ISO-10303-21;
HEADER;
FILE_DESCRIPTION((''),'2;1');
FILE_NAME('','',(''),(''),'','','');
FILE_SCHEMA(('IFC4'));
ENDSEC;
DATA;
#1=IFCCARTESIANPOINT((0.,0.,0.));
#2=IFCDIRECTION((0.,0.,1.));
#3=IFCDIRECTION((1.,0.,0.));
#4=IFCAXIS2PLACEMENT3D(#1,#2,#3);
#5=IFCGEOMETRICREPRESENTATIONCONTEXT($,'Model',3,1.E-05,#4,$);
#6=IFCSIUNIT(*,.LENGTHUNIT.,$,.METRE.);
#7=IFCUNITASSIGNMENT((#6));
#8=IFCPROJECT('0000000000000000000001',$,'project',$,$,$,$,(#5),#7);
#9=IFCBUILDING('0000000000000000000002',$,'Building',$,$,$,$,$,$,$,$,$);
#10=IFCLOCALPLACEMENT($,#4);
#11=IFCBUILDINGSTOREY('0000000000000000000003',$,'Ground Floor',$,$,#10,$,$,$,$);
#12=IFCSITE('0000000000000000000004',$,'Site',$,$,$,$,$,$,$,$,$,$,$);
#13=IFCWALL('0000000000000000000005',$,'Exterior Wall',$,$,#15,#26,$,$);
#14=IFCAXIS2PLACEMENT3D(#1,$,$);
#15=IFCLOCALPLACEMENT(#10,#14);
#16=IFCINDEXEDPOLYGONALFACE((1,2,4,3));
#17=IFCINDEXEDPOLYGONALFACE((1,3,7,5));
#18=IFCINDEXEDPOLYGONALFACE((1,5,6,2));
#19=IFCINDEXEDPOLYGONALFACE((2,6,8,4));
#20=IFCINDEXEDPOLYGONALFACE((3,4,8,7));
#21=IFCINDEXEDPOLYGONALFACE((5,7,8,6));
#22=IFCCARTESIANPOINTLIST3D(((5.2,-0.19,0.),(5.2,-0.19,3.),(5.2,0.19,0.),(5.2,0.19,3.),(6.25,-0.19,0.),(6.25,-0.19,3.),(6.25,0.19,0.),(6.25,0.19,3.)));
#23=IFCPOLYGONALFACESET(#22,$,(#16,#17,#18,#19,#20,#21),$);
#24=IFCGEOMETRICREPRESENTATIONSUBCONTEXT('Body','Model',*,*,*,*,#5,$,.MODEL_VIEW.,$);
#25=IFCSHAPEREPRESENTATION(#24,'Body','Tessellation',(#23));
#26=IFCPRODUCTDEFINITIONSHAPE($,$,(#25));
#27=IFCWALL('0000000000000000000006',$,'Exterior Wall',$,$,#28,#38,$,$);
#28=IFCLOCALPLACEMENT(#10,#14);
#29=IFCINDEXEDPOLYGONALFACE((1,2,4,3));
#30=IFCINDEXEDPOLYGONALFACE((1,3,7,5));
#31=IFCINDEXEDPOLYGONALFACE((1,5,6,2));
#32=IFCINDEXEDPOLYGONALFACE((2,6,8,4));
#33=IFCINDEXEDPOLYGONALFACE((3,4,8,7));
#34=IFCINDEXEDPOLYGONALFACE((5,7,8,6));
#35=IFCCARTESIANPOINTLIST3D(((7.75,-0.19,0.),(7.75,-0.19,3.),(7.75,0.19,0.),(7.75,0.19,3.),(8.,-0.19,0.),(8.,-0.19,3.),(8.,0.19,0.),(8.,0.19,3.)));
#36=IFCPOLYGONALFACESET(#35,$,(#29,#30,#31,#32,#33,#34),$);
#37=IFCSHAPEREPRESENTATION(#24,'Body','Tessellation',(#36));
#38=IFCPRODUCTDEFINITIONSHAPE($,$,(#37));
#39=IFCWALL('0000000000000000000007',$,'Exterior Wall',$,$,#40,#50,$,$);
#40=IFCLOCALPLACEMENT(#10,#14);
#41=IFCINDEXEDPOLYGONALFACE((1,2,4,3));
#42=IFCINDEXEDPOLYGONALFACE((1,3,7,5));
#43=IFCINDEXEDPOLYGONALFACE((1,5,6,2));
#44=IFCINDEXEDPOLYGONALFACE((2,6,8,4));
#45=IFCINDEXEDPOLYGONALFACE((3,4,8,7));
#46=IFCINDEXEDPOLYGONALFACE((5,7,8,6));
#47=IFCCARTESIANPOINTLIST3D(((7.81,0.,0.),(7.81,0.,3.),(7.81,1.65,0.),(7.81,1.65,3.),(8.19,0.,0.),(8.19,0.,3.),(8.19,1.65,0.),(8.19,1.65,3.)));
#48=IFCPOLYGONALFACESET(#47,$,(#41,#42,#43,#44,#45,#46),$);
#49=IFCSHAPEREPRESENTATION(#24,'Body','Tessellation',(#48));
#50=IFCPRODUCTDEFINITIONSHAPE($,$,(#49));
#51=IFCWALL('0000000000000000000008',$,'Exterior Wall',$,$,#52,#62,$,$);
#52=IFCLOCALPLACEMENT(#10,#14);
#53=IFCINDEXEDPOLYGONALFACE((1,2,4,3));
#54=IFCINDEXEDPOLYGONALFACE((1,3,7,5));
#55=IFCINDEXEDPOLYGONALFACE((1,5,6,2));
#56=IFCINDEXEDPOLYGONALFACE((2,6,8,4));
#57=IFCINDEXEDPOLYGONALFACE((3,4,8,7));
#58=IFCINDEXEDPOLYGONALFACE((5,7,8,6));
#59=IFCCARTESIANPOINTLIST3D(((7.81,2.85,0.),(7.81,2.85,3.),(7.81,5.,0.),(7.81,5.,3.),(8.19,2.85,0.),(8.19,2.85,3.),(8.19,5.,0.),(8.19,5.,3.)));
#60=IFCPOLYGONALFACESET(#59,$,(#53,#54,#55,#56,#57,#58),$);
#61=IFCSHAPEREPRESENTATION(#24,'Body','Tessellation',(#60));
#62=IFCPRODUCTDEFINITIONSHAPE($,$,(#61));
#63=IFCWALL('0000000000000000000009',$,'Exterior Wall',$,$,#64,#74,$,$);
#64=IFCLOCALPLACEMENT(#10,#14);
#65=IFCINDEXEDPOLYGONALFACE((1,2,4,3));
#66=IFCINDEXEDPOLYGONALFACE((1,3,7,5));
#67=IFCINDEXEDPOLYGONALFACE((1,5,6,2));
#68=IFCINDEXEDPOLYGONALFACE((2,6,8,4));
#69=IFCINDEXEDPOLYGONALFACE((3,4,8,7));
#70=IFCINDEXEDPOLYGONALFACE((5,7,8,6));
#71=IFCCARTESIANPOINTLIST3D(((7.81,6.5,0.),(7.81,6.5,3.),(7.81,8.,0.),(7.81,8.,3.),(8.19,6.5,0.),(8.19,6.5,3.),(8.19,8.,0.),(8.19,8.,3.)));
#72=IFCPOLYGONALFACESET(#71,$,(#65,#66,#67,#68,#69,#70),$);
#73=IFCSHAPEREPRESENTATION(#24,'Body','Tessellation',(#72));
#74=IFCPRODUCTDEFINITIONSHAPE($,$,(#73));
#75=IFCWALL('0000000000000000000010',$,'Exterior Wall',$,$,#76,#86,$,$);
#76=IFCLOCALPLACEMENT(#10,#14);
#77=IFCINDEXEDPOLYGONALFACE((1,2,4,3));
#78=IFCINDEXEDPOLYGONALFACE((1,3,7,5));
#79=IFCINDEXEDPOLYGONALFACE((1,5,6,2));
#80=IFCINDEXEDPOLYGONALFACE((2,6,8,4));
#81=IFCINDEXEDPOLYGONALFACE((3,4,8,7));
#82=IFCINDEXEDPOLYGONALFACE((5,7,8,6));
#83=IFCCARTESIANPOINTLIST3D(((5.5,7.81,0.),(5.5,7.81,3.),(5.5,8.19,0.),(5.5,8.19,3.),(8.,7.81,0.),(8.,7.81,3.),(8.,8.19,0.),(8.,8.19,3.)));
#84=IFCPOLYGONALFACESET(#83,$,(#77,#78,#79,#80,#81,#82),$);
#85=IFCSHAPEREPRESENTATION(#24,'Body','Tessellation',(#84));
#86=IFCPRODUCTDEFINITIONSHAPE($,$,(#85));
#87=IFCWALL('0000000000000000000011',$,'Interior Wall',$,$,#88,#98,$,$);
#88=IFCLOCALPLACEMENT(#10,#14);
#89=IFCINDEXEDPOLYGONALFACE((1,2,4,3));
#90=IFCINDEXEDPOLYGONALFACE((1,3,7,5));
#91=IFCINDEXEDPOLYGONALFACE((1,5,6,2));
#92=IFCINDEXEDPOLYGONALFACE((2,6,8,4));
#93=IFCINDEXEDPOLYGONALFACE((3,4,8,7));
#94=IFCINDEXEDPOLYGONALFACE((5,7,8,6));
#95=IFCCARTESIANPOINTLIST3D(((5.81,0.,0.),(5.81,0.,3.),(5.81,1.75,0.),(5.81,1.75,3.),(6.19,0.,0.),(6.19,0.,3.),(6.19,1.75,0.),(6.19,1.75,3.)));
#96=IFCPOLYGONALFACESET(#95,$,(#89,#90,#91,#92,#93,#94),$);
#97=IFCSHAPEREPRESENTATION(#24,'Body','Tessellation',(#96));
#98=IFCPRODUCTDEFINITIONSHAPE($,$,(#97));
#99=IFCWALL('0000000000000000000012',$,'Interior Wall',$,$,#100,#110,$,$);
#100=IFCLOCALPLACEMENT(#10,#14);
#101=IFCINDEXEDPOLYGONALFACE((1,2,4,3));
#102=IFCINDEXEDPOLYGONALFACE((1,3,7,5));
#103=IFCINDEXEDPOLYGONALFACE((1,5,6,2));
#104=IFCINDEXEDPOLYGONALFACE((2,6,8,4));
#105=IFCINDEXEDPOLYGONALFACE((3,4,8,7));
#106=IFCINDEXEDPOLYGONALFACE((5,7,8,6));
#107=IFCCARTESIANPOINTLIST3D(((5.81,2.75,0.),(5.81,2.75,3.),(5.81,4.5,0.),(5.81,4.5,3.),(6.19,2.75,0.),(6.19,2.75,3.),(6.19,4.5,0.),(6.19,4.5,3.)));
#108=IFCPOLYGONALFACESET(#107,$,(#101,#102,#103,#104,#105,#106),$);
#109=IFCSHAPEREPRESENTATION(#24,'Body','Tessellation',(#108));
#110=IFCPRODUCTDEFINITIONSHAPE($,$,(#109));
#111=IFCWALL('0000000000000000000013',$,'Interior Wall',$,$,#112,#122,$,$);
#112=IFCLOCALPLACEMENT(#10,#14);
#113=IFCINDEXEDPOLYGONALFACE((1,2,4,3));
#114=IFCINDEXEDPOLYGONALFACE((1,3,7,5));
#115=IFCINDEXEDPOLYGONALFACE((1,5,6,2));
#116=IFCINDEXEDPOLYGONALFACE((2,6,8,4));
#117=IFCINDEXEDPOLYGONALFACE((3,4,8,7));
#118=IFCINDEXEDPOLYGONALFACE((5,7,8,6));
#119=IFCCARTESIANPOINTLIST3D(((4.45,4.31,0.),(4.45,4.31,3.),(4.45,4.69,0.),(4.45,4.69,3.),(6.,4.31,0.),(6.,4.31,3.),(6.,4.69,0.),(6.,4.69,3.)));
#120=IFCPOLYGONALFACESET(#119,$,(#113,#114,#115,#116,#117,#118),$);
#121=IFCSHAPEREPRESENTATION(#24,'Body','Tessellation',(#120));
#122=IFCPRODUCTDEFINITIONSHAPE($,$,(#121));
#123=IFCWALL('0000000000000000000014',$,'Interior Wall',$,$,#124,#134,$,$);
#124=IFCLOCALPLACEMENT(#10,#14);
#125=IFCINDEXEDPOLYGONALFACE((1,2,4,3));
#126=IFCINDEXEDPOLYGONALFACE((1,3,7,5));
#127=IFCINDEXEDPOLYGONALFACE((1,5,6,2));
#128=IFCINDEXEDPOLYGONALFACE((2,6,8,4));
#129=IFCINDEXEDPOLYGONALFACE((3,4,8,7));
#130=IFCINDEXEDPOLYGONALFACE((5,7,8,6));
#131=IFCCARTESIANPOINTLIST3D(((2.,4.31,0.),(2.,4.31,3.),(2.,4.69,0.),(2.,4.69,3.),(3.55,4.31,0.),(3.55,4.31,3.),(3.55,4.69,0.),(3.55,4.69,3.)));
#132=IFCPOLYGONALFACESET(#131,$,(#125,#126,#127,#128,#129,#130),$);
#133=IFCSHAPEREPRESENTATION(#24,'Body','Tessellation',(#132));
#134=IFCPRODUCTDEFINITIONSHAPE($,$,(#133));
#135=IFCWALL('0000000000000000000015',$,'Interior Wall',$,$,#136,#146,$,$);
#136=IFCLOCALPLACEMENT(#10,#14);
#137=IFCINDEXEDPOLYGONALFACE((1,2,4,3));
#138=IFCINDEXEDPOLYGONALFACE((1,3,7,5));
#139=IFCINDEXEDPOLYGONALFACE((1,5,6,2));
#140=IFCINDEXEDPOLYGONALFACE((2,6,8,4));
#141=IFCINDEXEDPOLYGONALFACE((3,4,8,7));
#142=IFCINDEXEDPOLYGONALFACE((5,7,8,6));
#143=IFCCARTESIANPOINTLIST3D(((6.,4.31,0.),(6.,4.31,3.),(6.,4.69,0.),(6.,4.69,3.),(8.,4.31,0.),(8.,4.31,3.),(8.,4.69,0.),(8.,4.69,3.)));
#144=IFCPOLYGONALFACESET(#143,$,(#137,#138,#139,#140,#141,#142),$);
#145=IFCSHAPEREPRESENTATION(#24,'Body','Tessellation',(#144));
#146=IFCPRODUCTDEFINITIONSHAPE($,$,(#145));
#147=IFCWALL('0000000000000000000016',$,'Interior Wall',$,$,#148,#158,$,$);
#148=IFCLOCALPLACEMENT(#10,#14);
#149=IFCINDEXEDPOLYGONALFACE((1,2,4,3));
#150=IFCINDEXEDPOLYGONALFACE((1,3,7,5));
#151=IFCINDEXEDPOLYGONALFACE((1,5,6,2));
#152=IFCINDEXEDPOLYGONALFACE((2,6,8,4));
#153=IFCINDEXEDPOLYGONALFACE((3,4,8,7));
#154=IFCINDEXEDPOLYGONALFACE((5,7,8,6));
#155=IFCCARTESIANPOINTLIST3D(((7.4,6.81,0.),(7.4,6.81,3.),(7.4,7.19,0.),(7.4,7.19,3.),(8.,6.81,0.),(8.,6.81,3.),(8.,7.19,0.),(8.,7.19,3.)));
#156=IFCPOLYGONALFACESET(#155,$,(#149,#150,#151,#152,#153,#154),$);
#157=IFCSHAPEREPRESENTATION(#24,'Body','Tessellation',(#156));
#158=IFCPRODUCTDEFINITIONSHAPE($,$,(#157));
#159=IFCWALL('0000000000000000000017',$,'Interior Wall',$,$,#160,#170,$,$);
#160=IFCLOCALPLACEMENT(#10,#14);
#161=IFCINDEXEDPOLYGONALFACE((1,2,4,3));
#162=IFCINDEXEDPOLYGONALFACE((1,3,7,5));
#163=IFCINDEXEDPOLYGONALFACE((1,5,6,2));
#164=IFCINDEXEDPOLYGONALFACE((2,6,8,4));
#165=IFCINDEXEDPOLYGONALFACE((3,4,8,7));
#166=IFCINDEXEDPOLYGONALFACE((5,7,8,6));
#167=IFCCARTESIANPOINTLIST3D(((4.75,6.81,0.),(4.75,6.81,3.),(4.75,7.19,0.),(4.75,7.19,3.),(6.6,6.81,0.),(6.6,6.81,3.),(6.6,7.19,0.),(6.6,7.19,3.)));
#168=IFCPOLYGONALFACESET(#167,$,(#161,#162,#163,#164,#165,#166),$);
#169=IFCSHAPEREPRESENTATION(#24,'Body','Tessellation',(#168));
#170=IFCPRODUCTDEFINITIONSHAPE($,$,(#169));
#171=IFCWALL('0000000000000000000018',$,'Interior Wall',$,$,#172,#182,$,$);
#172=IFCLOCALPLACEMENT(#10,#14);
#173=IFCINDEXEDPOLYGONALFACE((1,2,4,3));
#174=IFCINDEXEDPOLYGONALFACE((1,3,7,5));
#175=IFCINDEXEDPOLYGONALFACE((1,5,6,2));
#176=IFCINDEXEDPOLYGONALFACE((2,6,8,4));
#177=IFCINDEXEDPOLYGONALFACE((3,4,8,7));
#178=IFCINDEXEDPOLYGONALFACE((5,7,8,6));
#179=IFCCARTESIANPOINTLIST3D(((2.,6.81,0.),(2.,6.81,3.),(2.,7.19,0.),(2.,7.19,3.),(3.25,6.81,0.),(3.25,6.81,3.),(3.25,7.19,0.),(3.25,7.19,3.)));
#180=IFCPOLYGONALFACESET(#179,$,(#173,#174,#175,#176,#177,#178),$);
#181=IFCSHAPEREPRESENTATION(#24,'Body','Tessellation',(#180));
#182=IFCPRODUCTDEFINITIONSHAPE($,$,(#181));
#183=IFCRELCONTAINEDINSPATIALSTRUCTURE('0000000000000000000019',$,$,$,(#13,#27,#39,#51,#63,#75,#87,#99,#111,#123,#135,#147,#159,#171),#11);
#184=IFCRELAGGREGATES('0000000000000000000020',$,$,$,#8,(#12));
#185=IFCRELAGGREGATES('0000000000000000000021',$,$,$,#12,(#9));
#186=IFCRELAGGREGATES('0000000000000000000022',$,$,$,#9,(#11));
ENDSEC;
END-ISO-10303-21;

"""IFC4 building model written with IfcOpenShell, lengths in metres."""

from ifc_helpers import new_model, si_unit, frame, origin_with_axes, place, context, subcontext, project, spatial, indexed_curve, outline, extrude, element, save


model = new_model("IFC4")

# Units and contexts
model_context = context("Model", 3, precision=1e-05, world=origin_with_axes())
body_context = subcontext(model_context, "Body", "Model", "MODEL_VIEW")
ifc_project = project(units=[si_unit("LENGTHUNIT", "METRE")], contexts=[model_context])

# Site, building, storey
site = spatial("IfcSite", under=ifc_project, Name="Site")
building = spatial("IfcBuilding", under=site, Name="Building")
storey_placement = place(None, origin_with_axes())
storey = spatial("IfcBuildingStorey", under=building, at=storey_placement, Name="Ground Floor")

# Walls
wall_1_placement = place(storey_placement, frame((5.2, 0.0, 0.0), z_axis=(0.0, 0.0, 1.0), x_axis=(1.0, 0.0, 0.0)))
element("IfcWall", 1, at=wall_1_placement, inside=storey, Name="Exterior Wall", context=body_context, shape_type="SweptSolid", body=[
    extrude(outline(indexed_curve([(0.0, 0.0), (0.0, 0.38), (1.05, 0.38), (1.05, 0.0), (0.0, 0.0)], self_intersect=False)), frame((0.0, -0.19, 0.0), z_axis=(0.0, 0.0, 1.0), x_axis=(1.0, 0.0, 0.0)), (0.0, 0.0, 1.0), 3.0),
])
wall_2_placement = place(storey_placement, frame((7.75, 0.0, 0.0), z_axis=(0.0, 0.0, 1.0), x_axis=(1.0, 0.0, 0.0)))
element("IfcWall", 2, at=wall_2_placement, inside=storey, Name="Exterior Wall", context=body_context, shape_type="SweptSolid", body=[
    extrude(outline(indexed_curve([(0.0, 0.0), (0.0, 0.38), (0.25, 0.38), (0.25, 0.0), (0.0, 0.0)], self_intersect=False)), frame((0.0, -0.19, 0.0), z_axis=(0.0, 0.0, 1.0), x_axis=(1.0, 0.0, 0.0)), (0.0, 0.0, 1.0), 3.0),
])
wall_3_placement = place(storey_placement, frame((8.0, 0.0, 0.0), z_axis=(0.0, 0.0, 1.0), x_axis=(0.0, 1.0, 0.0)))
element("IfcWall", 3, at=wall_3_placement, inside=storey, Name="Exterior Wall", context=body_context, shape_type="SweptSolid", body=[
    extrude(outline(indexed_curve([(0.0, 0.0), (0.0, 0.38), (1.65, 0.38), (1.65, 0.0), (0.0, 0.0)], self_intersect=False)), frame((0.0, -0.19, 0.0), z_axis=(0.0, 0.0, 1.0), x_axis=(1.0, 0.0, 0.0)), (0.0, 0.0, 1.0), 3.0),
])
wall_4_placement = place(storey_placement, frame((8.0, 2.85, 0.0), z_axis=(0.0, 0.0, 1.0), x_axis=(0.0, 1.0, 0.0)))
element("IfcWall", 4, at=wall_4_placement, inside=storey, Name="Exterior Wall", context=body_context, shape_type="SweptSolid", body=[
    extrude(outline(indexed_curve([(0.0, 0.0), (0.0, 0.38), (2.15, 0.38), (2.15, 0.0), (0.0, 0.0)], self_intersect=False)), frame((0.0, -0.19, 0.0), z_axis=(0.0, 0.0, 1.0), x_axis=(1.0, 0.0, 0.0)), (0.0, 0.0, 1.0), 3.0),
])
wall_5_placement = place(storey_placement, frame((8.0, 6.5, 0.0), z_axis=(0.0, 0.0, 1.0), x_axis=(0.0, 1.0, 0.0)))
element("IfcWall", 5, at=wall_5_placement, inside=storey, Name="Exterior Wall", context=body_context, shape_type="SweptSolid", body=[
    extrude(outline(indexed_curve([(0.0, 0.0), (0.0, 0.38), (1.5, 0.38), (1.5, 0.0), (0.0, 0.0)], self_intersect=False)), frame((0.0, -0.19, 0.0), z_axis=(0.0, 0.0, 1.0), x_axis=(1.0, 0.0, 0.0)), (0.0, 0.0, 1.0), 3.0),
])
wall_6_placement = place(storey_placement, frame((8.0, 8.0, 0.0), z_axis=(0.0, 0.0, 1.0), x_axis=(-1.0, 0.0, 0.0)))
element("IfcWall", 6, at=wall_6_placement, inside=storey, Name="Exterior Wall", context=body_context, shape_type="SweptSolid", body=[
    extrude(outline(indexed_curve([(0.0, 0.0), (0.0, 0.38), (2.5, 0.38), (2.5, 0.0), (0.0, 0.0)], self_intersect=False)), frame((0.0, -0.19, 0.0), z_axis=(0.0, 0.0, 1.0), x_axis=(1.0, 0.0, 0.0)), (0.0, 0.0, 1.0), 3.0),
])
for number, where, z_axis, x_axis, name in (
    (7, (6.0, 0.0, 0.0), (0.0, 0.0, 1.0), (0.0, 1.0, 0.0), "Interior Wall"),
    (8, (6.0, 2.75, 0.0), (0.0, 0.0, 1.0), (0.0, 1.0, 0.0), "Interior Wall"),
):
    element("IfcWall", number, at=place(storey_placement, frame(where, z_axis=z_axis, x_axis=x_axis)), inside=storey, Name=name, context=body_context, shape_type="SweptSolid", body=[
        extrude(outline(indexed_curve([(0.0, 0.0), (0.0, 0.38), (1.75, 0.38), (1.75, 0.0), (0.0, 0.0)], self_intersect=False)), frame((0.0, -0.19, 0.0), z_axis=(0.0, 0.0, 1.0), x_axis=(1.0, 0.0, 0.0)), (0.0, 0.0, 1.0), 3.0),
    ])
for number, where, z_axis, x_axis, name in (
    (9, (6.0, 4.5, 0.0), (0.0, 0.0, 1.0), (-1.0, 0.0, 0.0), "Interior Wall"),
    (10, (3.55, 4.5, 0.0), (0.0, 0.0, 1.0), (-1.0, 0.0, 0.0), "Interior Wall"),
):
    element("IfcWall", number, at=place(storey_placement, frame(where, z_axis=z_axis, x_axis=x_axis)), inside=storey, Name=name, context=body_context, shape_type="SweptSolid", body=[
        extrude(outline(indexed_curve([(0.0, 0.0), (0.0, 0.38), (1.55, 0.38), (1.55, 0.0), (0.0, 0.0)], self_intersect=False)), frame((0.0, -0.19, 0.0), z_axis=(0.0, 0.0, 1.0), x_axis=(1.0, 0.0, 0.0)), (0.0, 0.0, 1.0), 3.0),
    ])
wall_7_placement = place(storey_placement, frame((8.0, 4.5, 0.0), z_axis=(0.0, 0.0, 1.0), x_axis=(-1.0, 0.0, 0.0)))
element("IfcWall", 11, at=wall_7_placement, inside=storey, Name="Interior Wall", context=body_context, shape_type="SweptSolid", body=[
    extrude(outline(indexed_curve([(0.0, 0.0), (0.0, 0.38), (2.0, 0.38), (2.0, 0.0), (0.0, 0.0)], self_intersect=False)), frame((0.0, -0.19, 0.0), z_axis=(0.0, 0.0, 1.0), x_axis=(1.0, 0.0, 0.0)), (0.0, 0.0, 1.0), 3.0),
])
wall_8_placement = place(storey_placement, frame((8.0, 7.0, 0.0), z_axis=(0.0, 0.0, 1.0), x_axis=(-1.0, 0.0, 0.0)))
element("IfcWall", 12, at=wall_8_placement, inside=storey, Name="Interior Wall", context=body_context, shape_type="SweptSolid", body=[
    extrude(outline(indexed_curve([(0.0, 0.0), (0.0, 0.38), (0.6, 0.38), (0.6, 0.0), (0.0, 0.0)], self_intersect=False)), frame((0.0, -0.19, 0.0), z_axis=(0.0, 0.0, 1.0), x_axis=(1.0, 0.0, 0.0)), (0.0, 0.0, 1.0), 3.0),
])
wall_9_placement = place(storey_placement, frame((6.6, 7.0, 0.0), z_axis=(0.0, 0.0, 1.0), x_axis=(-1.0, 0.0, 0.0)))
element("IfcWall", 13, at=wall_9_placement, inside=storey, Name="Interior Wall", context=body_context, shape_type="SweptSolid", body=[
    extrude(outline(indexed_curve([(0.0, 0.0), (0.0, 0.38), (1.85, 0.38), (1.85, 0.0), (0.0, 0.0)], self_intersect=False)), frame((0.0, -0.19, 0.0), z_axis=(0.0, 0.0, 1.0), x_axis=(1.0, 0.0, 0.0)), (0.0, 0.0, 1.0), 3.0),
])
wall_10_placement = place(storey_placement, frame((3.25, 7.0, 0.0), z_axis=(0.0, 0.0, 1.0), x_axis=(-1.0, 0.0, 0.0)))
element("IfcWall", 14, at=wall_10_placement, inside=storey, Name="Interior Wall", context=body_context, shape_type="SweptSolid", body=[
    extrude(outline(indexed_curve([(0.0, 0.0), (0.0, 0.38), (1.25, 0.38), (1.25, 0.0), (0.0, 0.0)], self_intersect=False)), frame((0.0, -0.19, 0.0), z_axis=(0.0, 0.0, 1.0), x_axis=(1.0, 0.0, 0.0)), (0.0, 0.0, 1.0), 3.0),
])

save(model, "model.ifc")
